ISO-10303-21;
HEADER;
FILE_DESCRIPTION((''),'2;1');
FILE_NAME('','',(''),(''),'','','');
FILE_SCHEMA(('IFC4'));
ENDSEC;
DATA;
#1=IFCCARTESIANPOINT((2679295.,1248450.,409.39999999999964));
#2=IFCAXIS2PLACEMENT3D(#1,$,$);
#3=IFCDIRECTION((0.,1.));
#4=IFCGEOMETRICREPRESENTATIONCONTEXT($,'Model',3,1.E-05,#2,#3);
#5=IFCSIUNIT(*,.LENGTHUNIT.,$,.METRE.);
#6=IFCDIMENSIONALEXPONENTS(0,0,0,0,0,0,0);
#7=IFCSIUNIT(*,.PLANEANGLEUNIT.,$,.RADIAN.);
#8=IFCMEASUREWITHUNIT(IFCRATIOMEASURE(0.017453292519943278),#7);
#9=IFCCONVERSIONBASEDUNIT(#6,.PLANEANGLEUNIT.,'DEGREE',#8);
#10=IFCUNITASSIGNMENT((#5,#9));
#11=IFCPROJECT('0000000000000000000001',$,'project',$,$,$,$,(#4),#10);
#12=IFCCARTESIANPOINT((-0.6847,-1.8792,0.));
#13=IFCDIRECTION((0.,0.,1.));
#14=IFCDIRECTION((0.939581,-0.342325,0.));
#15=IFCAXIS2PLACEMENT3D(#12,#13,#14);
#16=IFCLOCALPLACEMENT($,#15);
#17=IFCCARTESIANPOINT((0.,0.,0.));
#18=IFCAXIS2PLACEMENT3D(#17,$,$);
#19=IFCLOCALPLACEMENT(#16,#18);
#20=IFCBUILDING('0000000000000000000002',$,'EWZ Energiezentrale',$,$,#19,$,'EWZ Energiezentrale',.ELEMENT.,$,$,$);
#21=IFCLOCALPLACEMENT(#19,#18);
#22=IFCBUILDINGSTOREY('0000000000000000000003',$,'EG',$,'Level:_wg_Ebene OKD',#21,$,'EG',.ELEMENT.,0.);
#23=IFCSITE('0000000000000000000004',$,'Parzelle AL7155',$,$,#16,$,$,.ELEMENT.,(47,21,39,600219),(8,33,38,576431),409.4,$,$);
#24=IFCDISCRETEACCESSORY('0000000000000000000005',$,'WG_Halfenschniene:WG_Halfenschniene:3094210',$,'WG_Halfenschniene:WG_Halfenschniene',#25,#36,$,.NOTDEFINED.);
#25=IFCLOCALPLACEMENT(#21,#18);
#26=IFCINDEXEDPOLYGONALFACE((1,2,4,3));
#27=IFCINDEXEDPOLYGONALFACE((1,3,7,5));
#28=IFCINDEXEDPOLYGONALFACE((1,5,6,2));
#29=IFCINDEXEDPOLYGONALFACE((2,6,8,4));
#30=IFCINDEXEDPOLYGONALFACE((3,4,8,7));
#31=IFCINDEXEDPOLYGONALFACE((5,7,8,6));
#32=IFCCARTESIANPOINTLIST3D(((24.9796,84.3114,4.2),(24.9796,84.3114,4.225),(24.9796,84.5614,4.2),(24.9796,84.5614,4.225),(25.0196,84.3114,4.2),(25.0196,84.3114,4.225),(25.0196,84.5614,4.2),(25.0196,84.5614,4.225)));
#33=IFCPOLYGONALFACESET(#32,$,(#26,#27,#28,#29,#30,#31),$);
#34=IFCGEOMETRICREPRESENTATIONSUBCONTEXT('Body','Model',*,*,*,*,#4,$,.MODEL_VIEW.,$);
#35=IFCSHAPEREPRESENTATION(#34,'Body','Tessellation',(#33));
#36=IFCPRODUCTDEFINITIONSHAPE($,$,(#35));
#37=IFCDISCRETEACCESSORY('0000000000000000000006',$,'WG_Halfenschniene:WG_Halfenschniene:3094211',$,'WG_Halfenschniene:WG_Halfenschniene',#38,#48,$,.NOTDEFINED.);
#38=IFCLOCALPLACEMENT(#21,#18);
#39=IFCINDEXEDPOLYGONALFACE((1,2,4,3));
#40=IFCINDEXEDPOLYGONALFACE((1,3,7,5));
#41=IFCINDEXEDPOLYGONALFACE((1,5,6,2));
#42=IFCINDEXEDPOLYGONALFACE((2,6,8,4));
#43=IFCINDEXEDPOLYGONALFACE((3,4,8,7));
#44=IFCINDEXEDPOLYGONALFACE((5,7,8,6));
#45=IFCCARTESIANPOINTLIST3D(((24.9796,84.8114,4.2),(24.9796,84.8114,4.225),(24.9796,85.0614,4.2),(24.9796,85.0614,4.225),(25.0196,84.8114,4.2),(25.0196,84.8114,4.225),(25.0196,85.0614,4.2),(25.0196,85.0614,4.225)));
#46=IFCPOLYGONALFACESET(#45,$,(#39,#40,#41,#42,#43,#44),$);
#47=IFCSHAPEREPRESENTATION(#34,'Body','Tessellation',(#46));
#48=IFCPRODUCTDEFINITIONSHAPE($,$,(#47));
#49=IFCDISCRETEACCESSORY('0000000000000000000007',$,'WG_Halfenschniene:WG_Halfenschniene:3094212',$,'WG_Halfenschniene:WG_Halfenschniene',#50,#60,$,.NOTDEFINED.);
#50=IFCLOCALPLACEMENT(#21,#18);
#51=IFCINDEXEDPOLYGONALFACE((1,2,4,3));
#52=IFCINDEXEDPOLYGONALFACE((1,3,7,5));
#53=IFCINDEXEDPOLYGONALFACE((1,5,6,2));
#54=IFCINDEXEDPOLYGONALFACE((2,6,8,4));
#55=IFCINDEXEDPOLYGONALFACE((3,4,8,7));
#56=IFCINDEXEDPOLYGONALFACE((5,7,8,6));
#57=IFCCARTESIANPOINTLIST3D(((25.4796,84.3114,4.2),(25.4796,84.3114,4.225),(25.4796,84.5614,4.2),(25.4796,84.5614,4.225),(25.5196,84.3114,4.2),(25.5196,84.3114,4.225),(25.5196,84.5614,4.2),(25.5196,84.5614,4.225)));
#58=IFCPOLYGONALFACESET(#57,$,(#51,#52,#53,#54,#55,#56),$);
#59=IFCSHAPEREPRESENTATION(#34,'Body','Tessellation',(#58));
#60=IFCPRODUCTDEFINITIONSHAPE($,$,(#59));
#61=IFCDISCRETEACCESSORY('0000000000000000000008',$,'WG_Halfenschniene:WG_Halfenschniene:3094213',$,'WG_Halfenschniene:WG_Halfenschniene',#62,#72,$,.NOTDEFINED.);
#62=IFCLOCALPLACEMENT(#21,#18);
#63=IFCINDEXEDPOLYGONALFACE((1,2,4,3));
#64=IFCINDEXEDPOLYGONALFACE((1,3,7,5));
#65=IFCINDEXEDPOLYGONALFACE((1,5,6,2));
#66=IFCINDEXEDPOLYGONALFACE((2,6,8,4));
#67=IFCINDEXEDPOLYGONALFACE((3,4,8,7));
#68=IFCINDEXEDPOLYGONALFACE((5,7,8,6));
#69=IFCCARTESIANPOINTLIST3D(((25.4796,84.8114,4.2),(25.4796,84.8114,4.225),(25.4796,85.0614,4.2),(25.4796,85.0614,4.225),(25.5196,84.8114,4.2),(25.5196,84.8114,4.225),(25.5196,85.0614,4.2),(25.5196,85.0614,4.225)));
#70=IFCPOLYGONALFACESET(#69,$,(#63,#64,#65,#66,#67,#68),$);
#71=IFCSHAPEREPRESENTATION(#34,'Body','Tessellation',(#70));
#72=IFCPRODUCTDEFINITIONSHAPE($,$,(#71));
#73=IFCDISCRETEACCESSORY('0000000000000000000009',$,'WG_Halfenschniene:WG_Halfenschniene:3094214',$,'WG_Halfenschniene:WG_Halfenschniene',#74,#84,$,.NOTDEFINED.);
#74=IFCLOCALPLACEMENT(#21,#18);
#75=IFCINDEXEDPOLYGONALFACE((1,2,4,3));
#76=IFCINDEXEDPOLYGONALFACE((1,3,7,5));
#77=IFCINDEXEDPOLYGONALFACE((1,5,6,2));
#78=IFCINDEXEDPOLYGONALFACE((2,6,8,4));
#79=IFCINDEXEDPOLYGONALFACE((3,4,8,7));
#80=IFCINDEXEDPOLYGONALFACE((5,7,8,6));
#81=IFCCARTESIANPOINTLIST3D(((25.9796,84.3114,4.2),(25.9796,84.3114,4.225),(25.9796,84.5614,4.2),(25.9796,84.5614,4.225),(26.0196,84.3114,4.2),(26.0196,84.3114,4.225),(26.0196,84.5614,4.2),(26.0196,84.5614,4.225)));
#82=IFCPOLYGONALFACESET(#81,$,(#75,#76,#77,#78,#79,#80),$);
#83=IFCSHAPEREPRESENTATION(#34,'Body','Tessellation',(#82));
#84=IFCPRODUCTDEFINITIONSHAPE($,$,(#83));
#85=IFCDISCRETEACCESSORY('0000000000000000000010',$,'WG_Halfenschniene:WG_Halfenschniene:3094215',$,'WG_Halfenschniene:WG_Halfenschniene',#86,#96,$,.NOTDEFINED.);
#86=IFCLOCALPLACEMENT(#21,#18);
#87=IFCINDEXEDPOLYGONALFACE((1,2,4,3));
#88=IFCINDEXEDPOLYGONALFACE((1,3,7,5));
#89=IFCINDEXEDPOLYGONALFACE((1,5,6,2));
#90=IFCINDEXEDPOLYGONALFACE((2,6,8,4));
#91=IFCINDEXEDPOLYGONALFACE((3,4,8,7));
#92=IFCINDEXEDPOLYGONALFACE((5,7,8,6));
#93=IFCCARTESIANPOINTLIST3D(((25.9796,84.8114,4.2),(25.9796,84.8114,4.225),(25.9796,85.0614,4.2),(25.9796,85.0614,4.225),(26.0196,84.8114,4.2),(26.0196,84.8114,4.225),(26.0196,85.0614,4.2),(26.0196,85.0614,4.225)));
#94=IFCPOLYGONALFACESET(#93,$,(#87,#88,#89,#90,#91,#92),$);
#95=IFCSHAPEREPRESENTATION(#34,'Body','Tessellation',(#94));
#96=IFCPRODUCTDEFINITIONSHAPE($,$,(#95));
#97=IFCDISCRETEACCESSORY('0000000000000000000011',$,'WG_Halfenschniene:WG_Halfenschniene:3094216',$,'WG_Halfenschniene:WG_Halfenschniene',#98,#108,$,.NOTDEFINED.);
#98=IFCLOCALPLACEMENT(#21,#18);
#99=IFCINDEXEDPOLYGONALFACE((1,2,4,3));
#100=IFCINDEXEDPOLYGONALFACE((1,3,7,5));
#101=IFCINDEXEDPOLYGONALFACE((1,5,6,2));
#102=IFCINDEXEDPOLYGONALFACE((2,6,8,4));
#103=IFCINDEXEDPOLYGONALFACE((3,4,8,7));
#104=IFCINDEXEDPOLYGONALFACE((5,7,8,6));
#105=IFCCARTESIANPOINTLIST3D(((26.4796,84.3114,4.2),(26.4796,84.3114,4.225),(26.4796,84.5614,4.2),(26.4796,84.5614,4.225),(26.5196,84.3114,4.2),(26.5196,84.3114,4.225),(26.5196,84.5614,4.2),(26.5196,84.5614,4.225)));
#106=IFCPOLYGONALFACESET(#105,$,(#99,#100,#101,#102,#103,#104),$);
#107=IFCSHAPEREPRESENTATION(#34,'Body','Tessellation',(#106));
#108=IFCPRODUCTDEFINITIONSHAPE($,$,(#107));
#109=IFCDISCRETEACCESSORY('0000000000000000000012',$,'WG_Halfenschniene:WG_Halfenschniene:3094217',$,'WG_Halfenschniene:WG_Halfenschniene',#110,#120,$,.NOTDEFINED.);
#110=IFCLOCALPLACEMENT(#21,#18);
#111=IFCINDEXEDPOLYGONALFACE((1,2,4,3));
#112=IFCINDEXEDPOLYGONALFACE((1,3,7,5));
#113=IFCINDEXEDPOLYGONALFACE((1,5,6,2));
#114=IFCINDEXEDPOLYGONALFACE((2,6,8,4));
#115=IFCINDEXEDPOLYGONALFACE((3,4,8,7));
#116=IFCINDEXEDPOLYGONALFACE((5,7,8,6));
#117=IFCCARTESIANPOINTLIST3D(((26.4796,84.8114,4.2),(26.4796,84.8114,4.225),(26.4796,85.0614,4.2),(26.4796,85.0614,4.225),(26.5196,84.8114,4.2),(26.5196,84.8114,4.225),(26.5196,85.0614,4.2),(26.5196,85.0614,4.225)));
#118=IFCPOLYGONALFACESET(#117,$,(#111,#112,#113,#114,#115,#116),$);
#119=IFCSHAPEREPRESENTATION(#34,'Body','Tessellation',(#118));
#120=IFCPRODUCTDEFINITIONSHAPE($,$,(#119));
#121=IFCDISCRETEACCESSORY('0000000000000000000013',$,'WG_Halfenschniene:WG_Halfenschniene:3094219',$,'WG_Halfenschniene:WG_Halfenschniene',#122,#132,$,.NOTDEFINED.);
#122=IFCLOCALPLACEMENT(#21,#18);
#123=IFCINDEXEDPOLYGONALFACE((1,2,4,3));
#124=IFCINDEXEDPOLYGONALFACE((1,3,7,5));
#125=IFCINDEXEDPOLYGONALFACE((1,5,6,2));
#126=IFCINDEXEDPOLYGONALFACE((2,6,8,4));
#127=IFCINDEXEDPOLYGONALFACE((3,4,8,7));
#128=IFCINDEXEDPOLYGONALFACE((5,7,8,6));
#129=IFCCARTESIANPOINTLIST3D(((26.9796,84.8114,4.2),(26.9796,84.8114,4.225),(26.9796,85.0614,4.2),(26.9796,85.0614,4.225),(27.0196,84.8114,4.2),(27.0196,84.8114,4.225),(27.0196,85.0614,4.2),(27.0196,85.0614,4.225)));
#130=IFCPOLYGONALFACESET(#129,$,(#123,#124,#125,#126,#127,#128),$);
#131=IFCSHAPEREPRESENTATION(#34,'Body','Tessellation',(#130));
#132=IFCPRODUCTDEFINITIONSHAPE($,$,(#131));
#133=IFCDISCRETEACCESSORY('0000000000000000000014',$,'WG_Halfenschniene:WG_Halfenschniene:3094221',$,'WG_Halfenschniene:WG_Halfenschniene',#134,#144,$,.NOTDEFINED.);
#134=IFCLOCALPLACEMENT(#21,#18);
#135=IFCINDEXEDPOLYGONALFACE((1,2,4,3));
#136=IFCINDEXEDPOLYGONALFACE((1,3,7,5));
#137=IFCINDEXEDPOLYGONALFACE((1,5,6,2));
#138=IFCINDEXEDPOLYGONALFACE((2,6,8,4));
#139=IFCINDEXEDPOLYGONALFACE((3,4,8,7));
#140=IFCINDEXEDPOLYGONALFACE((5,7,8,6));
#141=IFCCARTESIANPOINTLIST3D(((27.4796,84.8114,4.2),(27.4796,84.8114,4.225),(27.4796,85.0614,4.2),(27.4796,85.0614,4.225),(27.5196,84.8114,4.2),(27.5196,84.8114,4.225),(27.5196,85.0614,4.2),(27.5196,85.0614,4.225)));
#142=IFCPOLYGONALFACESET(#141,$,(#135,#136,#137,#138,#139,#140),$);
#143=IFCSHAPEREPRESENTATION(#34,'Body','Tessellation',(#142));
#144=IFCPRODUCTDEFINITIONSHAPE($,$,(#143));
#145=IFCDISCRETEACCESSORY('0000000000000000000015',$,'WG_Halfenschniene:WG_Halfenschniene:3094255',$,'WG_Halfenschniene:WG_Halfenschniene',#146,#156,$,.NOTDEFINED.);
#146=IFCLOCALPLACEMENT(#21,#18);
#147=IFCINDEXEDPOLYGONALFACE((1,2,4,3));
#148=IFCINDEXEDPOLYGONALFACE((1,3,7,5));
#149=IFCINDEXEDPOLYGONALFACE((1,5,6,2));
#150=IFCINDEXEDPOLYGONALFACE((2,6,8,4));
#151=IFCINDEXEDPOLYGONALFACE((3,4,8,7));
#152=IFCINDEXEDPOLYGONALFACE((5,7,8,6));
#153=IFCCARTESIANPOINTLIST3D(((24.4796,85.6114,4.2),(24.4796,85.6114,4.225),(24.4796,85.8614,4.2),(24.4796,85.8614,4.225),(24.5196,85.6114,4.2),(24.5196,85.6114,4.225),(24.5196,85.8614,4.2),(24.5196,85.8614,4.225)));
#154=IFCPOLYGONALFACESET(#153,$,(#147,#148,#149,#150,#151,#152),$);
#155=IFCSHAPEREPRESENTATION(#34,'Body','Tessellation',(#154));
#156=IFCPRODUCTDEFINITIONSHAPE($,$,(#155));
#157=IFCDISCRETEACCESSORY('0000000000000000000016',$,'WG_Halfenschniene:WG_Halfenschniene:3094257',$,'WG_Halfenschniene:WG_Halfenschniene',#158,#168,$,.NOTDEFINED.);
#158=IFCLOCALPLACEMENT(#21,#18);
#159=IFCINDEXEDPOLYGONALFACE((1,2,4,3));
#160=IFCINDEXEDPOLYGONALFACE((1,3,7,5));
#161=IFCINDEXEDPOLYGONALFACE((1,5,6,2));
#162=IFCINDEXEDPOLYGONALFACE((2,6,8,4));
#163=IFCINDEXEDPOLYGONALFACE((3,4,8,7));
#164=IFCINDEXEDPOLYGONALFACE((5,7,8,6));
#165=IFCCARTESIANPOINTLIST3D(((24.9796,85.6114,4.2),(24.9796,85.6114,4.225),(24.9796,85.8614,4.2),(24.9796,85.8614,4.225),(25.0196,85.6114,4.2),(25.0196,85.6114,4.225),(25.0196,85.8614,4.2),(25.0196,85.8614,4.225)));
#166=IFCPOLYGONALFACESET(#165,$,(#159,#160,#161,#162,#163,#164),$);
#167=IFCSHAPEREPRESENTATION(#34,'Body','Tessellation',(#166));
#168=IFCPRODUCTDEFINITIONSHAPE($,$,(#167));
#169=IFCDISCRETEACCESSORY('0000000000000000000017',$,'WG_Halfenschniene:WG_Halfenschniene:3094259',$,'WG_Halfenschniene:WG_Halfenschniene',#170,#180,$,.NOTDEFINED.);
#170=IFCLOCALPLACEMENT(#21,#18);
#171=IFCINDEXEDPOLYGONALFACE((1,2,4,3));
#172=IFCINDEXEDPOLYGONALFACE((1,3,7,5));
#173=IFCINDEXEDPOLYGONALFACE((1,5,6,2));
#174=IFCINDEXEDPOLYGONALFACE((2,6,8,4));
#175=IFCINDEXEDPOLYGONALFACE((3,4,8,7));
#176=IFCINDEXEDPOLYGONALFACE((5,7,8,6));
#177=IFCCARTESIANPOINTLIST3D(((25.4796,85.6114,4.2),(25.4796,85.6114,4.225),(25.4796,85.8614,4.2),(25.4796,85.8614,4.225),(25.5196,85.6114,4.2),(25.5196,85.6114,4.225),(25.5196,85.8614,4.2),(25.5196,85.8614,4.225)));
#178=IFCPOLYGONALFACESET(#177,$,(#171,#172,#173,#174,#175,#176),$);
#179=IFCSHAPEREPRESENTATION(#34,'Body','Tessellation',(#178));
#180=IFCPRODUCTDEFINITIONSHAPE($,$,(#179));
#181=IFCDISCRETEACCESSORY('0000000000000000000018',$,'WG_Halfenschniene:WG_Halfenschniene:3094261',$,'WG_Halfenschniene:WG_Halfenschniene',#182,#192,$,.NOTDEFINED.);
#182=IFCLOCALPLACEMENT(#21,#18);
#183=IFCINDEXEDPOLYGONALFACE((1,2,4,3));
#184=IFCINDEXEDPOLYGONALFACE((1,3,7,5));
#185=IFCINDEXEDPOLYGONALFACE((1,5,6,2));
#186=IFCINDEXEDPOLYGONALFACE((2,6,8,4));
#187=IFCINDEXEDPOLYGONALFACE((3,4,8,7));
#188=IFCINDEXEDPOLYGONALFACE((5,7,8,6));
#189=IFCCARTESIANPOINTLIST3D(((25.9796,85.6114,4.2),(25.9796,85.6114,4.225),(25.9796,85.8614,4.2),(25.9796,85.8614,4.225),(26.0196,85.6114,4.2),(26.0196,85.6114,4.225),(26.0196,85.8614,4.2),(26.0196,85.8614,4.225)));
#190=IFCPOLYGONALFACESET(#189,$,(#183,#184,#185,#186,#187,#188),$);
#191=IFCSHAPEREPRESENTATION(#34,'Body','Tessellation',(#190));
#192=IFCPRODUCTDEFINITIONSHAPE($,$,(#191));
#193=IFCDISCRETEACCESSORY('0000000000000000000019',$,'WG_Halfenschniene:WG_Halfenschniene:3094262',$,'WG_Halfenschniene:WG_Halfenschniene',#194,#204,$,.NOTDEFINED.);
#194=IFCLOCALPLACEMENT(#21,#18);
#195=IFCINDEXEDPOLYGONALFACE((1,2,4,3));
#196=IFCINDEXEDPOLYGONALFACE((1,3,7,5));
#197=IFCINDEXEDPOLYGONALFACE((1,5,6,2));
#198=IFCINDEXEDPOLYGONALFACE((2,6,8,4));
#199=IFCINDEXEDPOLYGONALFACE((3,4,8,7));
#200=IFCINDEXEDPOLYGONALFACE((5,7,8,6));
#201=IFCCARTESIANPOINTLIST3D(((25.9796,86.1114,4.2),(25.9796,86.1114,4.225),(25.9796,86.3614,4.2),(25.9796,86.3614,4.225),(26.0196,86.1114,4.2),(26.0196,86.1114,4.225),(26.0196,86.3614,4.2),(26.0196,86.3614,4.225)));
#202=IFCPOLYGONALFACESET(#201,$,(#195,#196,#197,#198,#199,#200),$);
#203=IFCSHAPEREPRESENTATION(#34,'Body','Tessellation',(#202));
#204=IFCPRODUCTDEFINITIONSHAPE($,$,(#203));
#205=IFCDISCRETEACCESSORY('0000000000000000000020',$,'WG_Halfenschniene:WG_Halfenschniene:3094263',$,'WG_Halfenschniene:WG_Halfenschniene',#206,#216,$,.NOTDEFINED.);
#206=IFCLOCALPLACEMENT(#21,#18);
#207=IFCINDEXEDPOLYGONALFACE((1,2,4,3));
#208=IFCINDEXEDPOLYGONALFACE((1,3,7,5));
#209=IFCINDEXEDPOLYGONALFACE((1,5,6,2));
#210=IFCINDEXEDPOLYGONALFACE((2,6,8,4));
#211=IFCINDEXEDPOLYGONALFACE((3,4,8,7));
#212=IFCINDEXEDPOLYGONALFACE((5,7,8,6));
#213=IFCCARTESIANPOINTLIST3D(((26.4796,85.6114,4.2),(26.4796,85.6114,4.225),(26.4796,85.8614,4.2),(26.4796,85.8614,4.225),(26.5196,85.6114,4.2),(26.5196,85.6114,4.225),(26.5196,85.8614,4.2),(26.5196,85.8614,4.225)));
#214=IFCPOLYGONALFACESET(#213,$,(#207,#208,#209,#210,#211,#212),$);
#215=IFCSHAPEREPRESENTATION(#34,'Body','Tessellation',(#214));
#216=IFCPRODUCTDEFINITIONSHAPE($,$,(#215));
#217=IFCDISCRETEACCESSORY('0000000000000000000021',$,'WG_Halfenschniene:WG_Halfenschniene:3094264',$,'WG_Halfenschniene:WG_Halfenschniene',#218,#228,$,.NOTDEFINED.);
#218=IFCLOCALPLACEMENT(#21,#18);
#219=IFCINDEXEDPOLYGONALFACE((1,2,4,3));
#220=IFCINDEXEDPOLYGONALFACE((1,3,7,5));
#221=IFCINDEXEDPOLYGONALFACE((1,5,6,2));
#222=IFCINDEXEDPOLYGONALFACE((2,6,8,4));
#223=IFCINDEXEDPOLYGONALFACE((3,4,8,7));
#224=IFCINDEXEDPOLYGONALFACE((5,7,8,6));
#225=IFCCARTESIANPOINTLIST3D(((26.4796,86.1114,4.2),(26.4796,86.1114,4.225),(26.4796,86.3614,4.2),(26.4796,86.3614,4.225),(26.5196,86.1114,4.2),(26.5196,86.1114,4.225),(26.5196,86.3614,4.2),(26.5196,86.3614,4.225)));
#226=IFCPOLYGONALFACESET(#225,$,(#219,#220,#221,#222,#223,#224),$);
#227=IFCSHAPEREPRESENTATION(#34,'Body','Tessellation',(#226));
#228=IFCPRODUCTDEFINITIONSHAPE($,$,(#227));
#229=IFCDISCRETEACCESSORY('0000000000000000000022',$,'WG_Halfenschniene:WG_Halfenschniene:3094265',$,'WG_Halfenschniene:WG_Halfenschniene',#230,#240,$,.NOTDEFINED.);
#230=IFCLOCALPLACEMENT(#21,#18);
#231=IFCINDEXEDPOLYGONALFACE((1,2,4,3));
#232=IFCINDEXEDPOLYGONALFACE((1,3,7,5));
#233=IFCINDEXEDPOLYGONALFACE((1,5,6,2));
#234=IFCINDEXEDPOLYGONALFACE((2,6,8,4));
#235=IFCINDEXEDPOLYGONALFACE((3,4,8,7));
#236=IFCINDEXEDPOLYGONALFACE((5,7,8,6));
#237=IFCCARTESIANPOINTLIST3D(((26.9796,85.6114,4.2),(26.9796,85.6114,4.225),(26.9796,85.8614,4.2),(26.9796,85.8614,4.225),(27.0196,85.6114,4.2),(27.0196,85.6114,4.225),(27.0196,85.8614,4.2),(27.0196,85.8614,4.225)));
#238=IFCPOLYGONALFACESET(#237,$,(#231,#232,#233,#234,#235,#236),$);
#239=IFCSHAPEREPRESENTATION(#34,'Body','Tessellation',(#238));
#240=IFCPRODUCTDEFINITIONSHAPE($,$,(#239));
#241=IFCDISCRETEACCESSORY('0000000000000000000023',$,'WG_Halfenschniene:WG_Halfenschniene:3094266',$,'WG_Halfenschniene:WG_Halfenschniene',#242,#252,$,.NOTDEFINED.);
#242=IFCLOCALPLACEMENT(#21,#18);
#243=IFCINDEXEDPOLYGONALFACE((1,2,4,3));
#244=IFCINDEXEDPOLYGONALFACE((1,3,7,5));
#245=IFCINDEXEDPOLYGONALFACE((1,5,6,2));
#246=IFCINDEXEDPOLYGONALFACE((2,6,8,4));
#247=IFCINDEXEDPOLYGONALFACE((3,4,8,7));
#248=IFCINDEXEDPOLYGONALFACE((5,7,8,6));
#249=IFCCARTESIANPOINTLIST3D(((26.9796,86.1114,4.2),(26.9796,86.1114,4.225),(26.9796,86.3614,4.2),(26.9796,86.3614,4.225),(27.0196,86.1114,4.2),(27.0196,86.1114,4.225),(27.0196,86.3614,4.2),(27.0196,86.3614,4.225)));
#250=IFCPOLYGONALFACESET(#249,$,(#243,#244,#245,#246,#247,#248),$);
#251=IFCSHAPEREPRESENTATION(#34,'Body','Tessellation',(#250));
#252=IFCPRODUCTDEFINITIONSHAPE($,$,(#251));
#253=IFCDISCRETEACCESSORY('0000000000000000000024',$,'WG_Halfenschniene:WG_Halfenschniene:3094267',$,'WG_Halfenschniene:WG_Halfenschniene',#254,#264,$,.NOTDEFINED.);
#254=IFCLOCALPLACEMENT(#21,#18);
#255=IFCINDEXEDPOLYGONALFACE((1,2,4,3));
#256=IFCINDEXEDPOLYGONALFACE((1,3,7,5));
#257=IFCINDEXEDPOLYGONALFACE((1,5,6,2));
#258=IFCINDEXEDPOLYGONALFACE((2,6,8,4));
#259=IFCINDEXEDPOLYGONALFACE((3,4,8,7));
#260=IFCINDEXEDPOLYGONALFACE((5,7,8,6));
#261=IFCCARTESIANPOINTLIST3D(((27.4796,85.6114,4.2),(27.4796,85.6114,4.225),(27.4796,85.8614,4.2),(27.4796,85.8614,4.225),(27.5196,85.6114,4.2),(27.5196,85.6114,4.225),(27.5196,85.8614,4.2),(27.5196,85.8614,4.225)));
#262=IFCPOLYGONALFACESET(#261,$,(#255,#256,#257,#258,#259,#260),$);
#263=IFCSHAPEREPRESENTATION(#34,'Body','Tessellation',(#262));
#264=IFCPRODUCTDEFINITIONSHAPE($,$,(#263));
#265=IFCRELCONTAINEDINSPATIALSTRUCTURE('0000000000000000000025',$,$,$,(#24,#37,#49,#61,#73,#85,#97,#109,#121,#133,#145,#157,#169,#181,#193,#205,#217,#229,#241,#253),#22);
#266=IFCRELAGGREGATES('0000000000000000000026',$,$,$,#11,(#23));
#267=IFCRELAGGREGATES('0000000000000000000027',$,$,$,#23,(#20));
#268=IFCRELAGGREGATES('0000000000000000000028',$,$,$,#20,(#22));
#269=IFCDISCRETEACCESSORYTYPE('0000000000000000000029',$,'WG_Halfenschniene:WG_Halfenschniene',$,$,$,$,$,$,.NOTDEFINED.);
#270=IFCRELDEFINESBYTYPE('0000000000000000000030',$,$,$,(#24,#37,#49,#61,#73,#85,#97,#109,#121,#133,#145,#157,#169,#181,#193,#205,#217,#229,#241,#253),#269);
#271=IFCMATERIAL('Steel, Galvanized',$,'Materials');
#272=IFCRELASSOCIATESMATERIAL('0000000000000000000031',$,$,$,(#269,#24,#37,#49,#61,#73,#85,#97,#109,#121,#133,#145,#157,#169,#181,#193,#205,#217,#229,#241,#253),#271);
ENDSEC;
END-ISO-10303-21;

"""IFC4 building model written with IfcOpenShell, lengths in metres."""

from ifc_helpers import new_model, entity, si_unit, converted_unit, direction, frame, origin, place, context, subcontext, project, spatial, indexed_curve, outline, extrude, source, transform, mapped, material, type_object, element, save


model = new_model("IFC4")

# Units and contexts
model_context = context("Model", 3, precision=1e-05, world=frame((2679295.0, 1248450.0, 409.39999999999964)), true_north=direction((0.0, 1.0)))
body_context = subcontext(model_context, "Body", "Model", "MODEL_VIEW")
ifc_project = project(units=[si_unit("LENGTHUNIT", "METRE"), converted_unit("PLANEANGLEUNIT", "DEGREE", entity("IfcRatioMeasure", 0.017453292519943278), si_unit("PLANEANGLEUNIT", "RADIAN"), dimensions=[0, 0, 0, 0, 0, 0, 0])], contexts=[model_context])

# Site, building, storey
site_placement = place(None, frame((-0.6847, -1.8792, 0.0), z_axis=(0.0, 0.0, 1.0), x_axis=(0.939581, -0.342325, 0.0)))
site = spatial("IfcSite", under=ifc_project, at=site_placement, Name="Parzelle AL7155", CompositionType="ELEMENT", RefLatitude=(47, 21, 39, 600219), RefLongitude=(8, 33, 38, 576431), RefElevation=409.4)
building_placement = place(site_placement, origin())
building = spatial("IfcBuilding", under=site, at=building_placement, Name="EWZ Energiezentrale", LongName="EWZ Energiezentrale", CompositionType="ELEMENT")
storey_placement = place(building_placement, origin())
storey = spatial("IfcBuildingStorey", under=building, at=storey_placement, Name="EG", ObjectType="Level:_wg_Ebene OKD", LongName="EG", CompositionType="ELEMENT", Elevation=0.0)

# Discrete accessories
ifc_material = material(Name="Steel, Galvanized", Category="Materials")
discrete_accessory_type = type_object("IfcDiscreteAccessoryType", Name="WG_Halfenschniene:WG_Halfenschniene", PredefinedType="NOTDEFINED", material=ifc_material)
shared_shape = source(origin(), body_context, "Body", "SweptSolid", [
    extrude(outline(indexed_curve([(-0.125, -0.02), (0.125, -0.02), (0.125, 0.02), (-0.125, 0.02), (-0.125, -0.02)], self_intersect=False)), frame((0.125, 0.0, -0.0125)), (0.0, 0.0, 1.0), 0.025),
])
for number, where, z_axis, x_axis, name in (
    (1, (24.9996, 84.3114, 4.2125), (0.0, 0.0, -1.0), (0.0, 1.0, 0.0), "WG_Halfenschniene:WG_Halfenschniene:3094210"),
    (2, (24.9996, 84.8114, 4.2125), (0.0, 0.0, -1.0), (0.0, 1.0, 0.0), "WG_Halfenschniene:WG_Halfenschniene:3094211"),
    (3, (25.4996, 84.3114, 4.2125), (0.0, 0.0, -1.0), (0.0, 1.0, 0.0), "WG_Halfenschniene:WG_Halfenschniene:3094212"),
    (4, (25.4996, 84.8114, 4.2125), (0.0, 0.0, -1.0), (0.0, 1.0, 0.0), "WG_Halfenschniene:WG_Halfenschniene:3094213"),
    (5, (25.9996, 84.3114, 4.2125), (0.0, 0.0, -1.0), (0.0, 1.0, 0.0), "WG_Halfenschniene:WG_Halfenschniene:3094214"),
    (6, (25.9996, 84.8114, 4.2125), (0.0, 0.0, -1.0), (0.0, 1.0, 0.0), "WG_Halfenschniene:WG_Halfenschniene:3094215"),
    (7, (26.4996, 84.3114, 4.2125), (0.0, 0.0, -1.0), (0.0, 1.0, 0.0), "WG_Halfenschniene:WG_Halfenschniene:3094216"),
    (8, (26.4996, 84.8114, 4.2125), (0.0, 0.0, -1.0), (0.0, 1.0, 0.0), "WG_Halfenschniene:WG_Halfenschniene:3094217"),
    (9, (26.9996, 84.8114, 4.2125), (0.0, 0.0, -1.0), (0.0, 1.0, 0.0), "WG_Halfenschniene:WG_Halfenschniene:3094219"),
    (10, (27.4996, 84.8114, 4.2125), (0.0, 0.0, -1.0), (0.0, 1.0, 0.0), "WG_Halfenschniene:WG_Halfenschniene:3094221"),
    (11, (24.4996, 85.6114, 4.2125), (0.0, 0.0, -1.0), (0.0, 1.0, 0.0), "WG_Halfenschniene:WG_Halfenschniene:3094255"),
    (12, (24.9996, 85.6114, 4.2125), (0.0, 0.0, -1.0), (0.0, 1.0, 0.0), "WG_Halfenschniene:WG_Halfenschniene:3094257"),
    (13, (25.4996, 85.6114, 4.2125), (0.0, 0.0, -1.0), (0.0, 1.0, 0.0), "WG_Halfenschniene:WG_Halfenschniene:3094259"),
    (14, (25.9996, 85.6114, 4.2125), (0.0, 0.0, -1.0), (0.0, 1.0, 0.0), "WG_Halfenschniene:WG_Halfenschniene:3094261"),
    (15, (25.9996, 86.1114, 4.2125), (0.0, 0.0, -1.0), (0.0, 1.0, 0.0), "WG_Halfenschniene:WG_Halfenschniene:3094262"),
    (16, (26.4996, 85.6114, 4.2125), (0.0, 0.0, -1.0), (0.0, 1.0, 0.0), "WG_Halfenschniene:WG_Halfenschniene:3094263"),
    (17, (26.4996, 86.1114, 4.2125), (0.0, 0.0, -1.0), (0.0, 1.0, 0.0), "WG_Halfenschniene:WG_Halfenschniene:3094264"),
    (18, (26.9996, 85.6114, 4.2125), (0.0, 0.0, -1.0), (0.0, 1.0, 0.0), "WG_Halfenschniene:WG_Halfenschniene:3094265"),
    (19, (26.9996, 86.1114, 4.2125), (0.0, 0.0, -1.0), (0.0, 1.0, 0.0), "WG_Halfenschniene:WG_Halfenschniene:3094266"),
    (20, (27.4996, 85.6114, 4.2125), (0.0, 0.0, -1.0), (0.0, 1.0, 0.0), "WG_Halfenschniene:WG_Halfenschniene:3094267"),
):
    element("IfcDiscreteAccessory", number, at=place(storey_placement, frame(where, z_axis=z_axis, x_axis=x_axis)), inside=storey, type_object=discrete_accessory_type, material=ifc_material, Name=name, ObjectType="WG_Halfenschniene:WG_Halfenschniene", PredefinedType="NOTDEFINED", context=body_context, shape_type="MappedRepresentation", body=[
        mapped(shared_shape, transform((0.0, 0.0, 0.0), scale=1.0)),
    ])

save(model, "model.ifc")
